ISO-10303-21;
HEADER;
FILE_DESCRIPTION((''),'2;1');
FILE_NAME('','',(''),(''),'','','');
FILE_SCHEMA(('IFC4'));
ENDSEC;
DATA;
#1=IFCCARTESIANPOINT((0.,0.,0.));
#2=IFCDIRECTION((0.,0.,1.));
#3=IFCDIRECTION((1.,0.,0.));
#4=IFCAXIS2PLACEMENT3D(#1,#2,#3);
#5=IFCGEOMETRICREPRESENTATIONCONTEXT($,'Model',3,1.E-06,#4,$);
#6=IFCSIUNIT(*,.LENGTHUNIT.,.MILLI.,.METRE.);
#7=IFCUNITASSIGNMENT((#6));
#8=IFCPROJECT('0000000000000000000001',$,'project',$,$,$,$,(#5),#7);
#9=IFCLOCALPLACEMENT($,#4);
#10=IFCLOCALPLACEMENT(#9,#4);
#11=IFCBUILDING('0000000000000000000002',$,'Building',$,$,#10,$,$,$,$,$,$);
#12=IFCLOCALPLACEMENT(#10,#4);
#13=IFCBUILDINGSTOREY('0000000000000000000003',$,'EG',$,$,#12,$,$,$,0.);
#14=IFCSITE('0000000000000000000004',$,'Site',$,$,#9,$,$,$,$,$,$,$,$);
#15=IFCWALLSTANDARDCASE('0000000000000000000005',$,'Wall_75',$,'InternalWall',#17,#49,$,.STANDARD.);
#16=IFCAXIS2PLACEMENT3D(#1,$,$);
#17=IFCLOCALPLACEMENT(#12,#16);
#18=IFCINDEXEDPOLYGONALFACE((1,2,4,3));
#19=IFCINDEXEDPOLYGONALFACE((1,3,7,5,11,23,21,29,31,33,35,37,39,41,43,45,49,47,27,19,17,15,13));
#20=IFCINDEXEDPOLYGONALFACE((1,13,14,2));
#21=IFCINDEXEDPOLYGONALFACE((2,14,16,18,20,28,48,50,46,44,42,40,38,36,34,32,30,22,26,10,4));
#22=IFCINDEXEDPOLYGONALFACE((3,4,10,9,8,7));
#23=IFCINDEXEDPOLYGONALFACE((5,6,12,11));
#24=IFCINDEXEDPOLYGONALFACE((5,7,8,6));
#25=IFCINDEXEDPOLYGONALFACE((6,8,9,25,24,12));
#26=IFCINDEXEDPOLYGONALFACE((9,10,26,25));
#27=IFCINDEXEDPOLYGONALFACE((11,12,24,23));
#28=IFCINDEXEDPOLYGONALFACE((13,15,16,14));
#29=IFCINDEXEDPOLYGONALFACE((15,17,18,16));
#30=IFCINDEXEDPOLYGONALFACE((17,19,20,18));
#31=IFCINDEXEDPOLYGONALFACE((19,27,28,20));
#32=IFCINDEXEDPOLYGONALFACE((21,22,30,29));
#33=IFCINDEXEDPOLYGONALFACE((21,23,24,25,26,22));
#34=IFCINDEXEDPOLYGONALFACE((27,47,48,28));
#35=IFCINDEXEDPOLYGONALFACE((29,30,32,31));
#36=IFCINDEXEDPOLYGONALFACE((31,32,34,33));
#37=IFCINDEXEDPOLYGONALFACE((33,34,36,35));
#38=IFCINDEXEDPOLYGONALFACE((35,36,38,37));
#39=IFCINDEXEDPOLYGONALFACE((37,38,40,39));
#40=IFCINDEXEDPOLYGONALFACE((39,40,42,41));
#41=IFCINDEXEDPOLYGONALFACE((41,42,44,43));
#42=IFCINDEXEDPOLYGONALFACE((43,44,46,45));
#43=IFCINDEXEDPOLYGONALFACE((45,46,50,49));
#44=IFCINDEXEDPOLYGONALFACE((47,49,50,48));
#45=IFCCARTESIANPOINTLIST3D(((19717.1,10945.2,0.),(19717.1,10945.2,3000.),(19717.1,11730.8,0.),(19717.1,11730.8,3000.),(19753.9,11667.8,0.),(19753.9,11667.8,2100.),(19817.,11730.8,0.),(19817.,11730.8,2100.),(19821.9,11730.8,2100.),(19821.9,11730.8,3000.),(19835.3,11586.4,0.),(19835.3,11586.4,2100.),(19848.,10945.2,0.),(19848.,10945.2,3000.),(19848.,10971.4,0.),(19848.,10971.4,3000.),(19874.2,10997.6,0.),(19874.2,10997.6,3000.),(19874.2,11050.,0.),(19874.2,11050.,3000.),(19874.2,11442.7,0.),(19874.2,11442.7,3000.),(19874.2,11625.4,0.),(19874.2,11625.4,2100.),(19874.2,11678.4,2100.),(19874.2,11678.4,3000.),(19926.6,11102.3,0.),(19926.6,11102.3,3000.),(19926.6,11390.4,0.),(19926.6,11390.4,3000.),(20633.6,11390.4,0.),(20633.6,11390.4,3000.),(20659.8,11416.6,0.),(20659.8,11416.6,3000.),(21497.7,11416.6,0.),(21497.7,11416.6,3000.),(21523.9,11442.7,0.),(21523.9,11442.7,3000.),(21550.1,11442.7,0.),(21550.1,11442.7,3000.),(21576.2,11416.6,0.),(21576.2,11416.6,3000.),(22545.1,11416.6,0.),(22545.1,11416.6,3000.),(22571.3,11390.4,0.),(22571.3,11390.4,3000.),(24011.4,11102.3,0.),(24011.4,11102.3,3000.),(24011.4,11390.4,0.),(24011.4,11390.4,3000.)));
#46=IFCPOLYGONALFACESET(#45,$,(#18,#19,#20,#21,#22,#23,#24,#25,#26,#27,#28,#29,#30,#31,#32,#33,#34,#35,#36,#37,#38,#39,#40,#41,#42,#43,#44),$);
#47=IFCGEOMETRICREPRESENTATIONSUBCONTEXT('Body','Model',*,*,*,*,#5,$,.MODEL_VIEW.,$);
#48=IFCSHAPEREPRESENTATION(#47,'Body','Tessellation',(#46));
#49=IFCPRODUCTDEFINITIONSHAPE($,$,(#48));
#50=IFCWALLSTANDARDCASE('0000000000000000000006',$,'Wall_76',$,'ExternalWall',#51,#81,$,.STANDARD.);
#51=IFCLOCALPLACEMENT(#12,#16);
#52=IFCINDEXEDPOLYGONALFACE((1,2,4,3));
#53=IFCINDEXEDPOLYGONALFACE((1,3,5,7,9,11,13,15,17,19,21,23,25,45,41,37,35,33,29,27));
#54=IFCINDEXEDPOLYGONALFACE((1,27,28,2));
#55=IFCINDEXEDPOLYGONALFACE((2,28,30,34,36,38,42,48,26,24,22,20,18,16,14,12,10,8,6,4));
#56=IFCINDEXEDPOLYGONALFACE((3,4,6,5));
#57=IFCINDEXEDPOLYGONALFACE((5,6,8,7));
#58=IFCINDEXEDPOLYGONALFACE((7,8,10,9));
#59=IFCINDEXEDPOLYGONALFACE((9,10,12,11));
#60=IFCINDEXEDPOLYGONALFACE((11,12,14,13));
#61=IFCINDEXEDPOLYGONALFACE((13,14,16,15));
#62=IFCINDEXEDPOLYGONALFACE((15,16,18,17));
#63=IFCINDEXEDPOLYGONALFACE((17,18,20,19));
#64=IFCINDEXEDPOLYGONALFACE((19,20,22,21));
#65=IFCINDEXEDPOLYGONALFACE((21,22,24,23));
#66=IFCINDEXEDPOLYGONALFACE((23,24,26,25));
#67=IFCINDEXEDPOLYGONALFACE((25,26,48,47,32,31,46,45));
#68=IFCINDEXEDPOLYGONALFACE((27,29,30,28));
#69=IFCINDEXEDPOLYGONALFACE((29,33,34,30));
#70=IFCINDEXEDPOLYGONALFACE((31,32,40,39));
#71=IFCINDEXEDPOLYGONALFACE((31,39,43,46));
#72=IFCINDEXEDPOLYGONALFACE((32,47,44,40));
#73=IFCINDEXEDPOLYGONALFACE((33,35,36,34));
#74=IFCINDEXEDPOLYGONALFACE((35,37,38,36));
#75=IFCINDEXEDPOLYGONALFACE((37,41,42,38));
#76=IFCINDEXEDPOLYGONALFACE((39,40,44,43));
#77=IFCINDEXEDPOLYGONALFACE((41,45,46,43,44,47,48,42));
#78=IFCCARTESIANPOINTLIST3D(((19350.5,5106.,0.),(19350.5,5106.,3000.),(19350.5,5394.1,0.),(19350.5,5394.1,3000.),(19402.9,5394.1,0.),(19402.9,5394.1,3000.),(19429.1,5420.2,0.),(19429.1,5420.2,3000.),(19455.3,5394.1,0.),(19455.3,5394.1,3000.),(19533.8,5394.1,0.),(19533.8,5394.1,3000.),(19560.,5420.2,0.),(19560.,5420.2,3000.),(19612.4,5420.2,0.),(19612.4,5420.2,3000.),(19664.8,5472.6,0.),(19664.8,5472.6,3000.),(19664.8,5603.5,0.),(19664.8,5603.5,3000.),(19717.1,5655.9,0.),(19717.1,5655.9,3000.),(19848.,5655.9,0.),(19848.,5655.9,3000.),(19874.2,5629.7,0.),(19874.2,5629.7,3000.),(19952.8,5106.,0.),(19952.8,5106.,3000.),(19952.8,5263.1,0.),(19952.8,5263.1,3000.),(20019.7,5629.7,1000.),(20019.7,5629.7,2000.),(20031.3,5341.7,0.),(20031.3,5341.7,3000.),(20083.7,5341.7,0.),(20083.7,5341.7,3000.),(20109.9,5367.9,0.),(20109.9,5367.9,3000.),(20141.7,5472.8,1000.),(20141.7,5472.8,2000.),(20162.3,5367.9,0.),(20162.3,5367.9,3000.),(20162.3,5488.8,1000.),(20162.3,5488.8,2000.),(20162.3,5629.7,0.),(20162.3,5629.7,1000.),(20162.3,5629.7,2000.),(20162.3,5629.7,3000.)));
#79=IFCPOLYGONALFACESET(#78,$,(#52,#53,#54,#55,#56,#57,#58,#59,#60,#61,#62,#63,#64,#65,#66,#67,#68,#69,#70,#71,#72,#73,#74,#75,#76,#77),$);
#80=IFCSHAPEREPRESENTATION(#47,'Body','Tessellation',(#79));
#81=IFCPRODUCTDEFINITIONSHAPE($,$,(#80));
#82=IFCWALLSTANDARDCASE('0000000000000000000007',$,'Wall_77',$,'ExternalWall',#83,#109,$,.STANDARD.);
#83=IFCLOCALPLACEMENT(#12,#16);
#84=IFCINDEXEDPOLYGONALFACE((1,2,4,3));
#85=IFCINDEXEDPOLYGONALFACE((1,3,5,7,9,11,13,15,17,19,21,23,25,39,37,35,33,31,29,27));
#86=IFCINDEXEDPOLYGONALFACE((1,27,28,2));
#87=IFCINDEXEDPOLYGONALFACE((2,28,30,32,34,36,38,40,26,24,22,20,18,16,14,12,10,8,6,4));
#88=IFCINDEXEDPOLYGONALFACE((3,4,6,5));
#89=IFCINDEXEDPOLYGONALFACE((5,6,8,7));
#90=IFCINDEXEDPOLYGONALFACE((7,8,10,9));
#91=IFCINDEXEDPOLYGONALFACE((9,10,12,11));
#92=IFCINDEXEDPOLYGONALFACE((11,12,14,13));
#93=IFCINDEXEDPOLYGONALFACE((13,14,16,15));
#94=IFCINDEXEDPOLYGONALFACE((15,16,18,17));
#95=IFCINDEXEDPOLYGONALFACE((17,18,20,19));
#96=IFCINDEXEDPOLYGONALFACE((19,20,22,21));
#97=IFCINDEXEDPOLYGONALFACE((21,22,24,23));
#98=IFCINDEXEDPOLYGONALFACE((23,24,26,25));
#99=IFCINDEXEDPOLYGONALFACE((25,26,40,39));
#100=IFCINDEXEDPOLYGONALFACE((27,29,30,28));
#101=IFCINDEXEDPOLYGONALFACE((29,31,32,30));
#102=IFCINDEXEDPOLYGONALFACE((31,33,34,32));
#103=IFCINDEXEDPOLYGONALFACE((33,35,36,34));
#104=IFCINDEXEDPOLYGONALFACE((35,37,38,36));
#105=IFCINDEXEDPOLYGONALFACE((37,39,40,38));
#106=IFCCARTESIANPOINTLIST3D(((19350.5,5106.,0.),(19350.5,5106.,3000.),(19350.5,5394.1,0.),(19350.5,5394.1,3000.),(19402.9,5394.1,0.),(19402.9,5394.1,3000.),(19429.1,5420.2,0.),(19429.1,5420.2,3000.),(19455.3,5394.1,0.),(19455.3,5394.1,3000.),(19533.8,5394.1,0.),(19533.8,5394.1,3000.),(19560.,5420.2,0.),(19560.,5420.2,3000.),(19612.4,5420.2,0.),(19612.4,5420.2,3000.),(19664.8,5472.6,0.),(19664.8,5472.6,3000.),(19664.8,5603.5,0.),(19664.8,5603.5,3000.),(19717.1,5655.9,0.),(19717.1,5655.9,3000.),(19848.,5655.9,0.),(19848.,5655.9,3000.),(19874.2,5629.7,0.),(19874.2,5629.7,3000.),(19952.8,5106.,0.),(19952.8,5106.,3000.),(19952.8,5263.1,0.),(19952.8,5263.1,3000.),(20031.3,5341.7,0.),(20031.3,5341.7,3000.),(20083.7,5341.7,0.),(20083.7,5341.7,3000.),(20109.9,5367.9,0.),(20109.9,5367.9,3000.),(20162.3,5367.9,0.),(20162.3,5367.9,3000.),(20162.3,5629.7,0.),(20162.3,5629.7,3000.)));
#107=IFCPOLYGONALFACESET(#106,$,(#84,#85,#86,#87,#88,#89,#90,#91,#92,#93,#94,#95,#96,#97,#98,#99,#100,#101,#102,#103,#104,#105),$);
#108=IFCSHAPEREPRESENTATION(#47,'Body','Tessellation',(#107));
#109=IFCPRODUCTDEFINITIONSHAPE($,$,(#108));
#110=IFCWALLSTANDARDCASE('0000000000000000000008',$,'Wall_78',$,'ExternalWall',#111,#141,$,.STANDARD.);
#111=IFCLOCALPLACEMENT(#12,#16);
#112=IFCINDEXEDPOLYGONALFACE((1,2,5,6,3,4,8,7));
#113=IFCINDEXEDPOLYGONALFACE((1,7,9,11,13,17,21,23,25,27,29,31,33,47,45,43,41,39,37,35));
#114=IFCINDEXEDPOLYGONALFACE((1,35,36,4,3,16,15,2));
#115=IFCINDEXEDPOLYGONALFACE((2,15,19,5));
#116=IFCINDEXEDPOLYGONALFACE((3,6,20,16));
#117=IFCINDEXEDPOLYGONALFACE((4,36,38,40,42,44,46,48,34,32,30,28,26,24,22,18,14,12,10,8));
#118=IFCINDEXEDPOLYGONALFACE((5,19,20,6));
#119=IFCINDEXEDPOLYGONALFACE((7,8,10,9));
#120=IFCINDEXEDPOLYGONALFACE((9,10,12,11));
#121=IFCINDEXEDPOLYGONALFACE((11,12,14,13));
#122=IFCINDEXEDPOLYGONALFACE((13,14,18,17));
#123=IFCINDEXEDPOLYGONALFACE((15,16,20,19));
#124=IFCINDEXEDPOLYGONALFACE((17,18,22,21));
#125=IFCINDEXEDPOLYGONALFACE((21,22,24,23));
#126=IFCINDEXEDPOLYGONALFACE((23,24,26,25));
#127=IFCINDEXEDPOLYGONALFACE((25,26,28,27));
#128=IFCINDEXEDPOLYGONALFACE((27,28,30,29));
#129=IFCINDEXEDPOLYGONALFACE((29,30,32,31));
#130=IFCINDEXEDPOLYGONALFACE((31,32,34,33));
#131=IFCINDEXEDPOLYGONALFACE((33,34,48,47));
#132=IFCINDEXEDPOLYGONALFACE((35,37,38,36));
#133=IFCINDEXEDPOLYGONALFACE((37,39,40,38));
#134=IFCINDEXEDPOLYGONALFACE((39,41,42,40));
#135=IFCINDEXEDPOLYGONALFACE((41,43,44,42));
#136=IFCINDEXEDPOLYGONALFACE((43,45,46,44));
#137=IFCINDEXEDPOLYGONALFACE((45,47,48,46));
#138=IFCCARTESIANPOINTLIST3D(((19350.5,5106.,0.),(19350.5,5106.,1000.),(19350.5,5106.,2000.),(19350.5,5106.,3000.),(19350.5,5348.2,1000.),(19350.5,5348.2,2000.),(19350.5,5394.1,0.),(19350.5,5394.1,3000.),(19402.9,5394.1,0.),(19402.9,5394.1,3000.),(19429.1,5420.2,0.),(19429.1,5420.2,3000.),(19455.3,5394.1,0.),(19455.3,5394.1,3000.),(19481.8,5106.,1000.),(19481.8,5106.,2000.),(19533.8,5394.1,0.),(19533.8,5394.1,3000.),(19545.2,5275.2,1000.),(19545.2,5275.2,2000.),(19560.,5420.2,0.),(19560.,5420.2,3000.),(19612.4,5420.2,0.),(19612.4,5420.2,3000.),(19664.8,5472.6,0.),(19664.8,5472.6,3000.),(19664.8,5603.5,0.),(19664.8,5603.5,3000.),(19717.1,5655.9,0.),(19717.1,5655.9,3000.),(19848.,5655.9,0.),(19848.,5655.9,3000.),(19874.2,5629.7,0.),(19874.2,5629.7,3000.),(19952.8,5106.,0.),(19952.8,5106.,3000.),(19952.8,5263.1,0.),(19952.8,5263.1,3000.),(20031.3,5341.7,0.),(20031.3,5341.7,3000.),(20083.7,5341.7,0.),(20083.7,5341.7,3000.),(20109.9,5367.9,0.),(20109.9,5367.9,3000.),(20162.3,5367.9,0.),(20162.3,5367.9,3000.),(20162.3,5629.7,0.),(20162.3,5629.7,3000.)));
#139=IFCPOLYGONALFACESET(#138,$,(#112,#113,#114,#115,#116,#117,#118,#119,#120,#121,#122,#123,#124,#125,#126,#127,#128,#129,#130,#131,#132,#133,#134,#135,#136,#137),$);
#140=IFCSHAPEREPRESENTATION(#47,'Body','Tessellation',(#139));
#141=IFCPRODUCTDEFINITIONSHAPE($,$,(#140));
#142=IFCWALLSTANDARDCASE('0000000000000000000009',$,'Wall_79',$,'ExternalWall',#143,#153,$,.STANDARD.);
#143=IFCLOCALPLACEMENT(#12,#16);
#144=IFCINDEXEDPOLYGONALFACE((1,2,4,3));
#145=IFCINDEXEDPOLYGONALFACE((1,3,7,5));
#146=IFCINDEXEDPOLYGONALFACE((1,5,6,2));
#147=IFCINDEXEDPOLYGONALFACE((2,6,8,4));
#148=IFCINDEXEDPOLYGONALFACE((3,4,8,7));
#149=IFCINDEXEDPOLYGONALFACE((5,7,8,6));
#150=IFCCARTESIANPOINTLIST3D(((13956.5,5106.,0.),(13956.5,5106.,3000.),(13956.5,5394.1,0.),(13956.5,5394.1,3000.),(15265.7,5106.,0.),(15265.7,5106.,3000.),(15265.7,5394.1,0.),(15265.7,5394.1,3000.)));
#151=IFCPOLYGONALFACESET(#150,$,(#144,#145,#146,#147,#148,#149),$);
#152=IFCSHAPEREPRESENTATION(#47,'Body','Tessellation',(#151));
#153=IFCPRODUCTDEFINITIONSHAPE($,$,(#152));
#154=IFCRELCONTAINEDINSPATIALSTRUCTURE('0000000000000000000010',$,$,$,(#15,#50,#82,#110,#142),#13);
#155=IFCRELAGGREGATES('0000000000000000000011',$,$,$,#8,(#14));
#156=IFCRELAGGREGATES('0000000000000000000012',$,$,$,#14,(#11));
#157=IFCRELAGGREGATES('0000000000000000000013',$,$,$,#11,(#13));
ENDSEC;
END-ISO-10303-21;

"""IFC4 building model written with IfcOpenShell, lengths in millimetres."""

from ifc_helpers import new_model, si_unit, frame, origin_with_axes, place, context, subcontext, project, spatial, polyline, rectangle, outline, extrude, element, save


model = new_model("IFC4")

# Units and contexts
model_context = context("Model", 3, precision=1e-06, world=origin_with_axes())
body_context = subcontext(model_context, "Body", "Model", "MODEL_VIEW")
ifc_project = project(units=[si_unit("LENGTHUNIT", "METRE", prefix="MILLI")], contexts=[model_context])

# Site, building, storey
site_placement = place(None, origin_with_axes())
site = spatial("IfcSite", under=ifc_project, at=site_placement, Name="Site")
building_placement = place(site_placement, origin_with_axes())
building = spatial("IfcBuilding", under=site, at=building_placement, Name="Building")
storey_placement = place(building_placement, origin_with_axes())
storey = spatial("IfcBuildingStorey", under=building, at=storey_placement, Name="EG", Elevation=0.0)

# Walls, openings
wall_1_placement = place(storey_placement, origin_with_axes())
wall_1 = element("IfcWallStandardCase", 1, at=wall_1_placement, inside=storey, Name="Wall_75", ObjectType="InternalWall", PredefinedType="STANDARD", context=body_context, shape_type="SweptSolid", body=[
    extrude(outline(polyline([(19717.1, 10945.2, 0.0), (19717.1, 11730.8, 0.0), (19821.9, 11730.8, 0.0), (19874.2, 11678.4, 0.0), (19874.2, 11442.7, 0.0), (19926.6, 11390.4, 0.0), (20633.6, 11390.4, 0.0), (20659.8, 11416.6, 0.0), (21497.7, 11416.6, 0.0), (21523.9, 11442.7, 0.0), (21550.1, 11442.7, 0.0), (21576.2, 11416.6, 0.0), (22545.1, 11416.6, 0.0), (22571.3, 11390.4, 0.0), (24011.4, 11390.4, 0.0), (24011.4, 11102.3, 0.0), (19926.6, 11102.3, 0.0), (19874.2, 11050.0, 0.0), (19874.2, 10997.6, 0.0), (19848.0, 10971.4, 0.0), (19848.0, 10945.2, 0.0), (19717.1, 10945.2, 0.0)])), origin_with_axes(), (0.0, 0.0, 1.0), 3000.0),
])
opening_1_placement = place(wall_1_placement, origin_with_axes())
element("IfcOpeningElement", 2, at=opening_1_placement, inside=storey, cuts=wall_1, context=body_context, shape_type="SweptSolid", body=[
    extrude(rectangle(XDim=907.3, YDim=115.0), frame((20115.4, 11947.9, 0.0), z_axis=(0.0, 0.0, 1.0), x_axis=(0.707107, 0.707107, 0.0)), (0.0, 0.0, 1.0), 2100.0),
])
wall_2_placement = place(storey_placement, origin_with_axes())
wall_2 = element("IfcWallStandardCase", 3, at=wall_2_placement, inside=storey, Name="Wall_76", ObjectType="ExternalWall", PredefinedType="STANDARD", context=body_context, shape_type="SweptSolid", body=[
    extrude(outline(polyline([(19350.5, 5106.0, 0.0), (19350.5, 5394.1, 0.0), (19402.9, 5394.1, 0.0), (19429.1, 5420.2, 0.0), (19455.3, 5394.1, 0.0), (19533.8, 5394.1, 0.0), (19560.0, 5420.2, 0.0), (19612.4, 5420.2, 0.0), (19664.8, 5472.6, 0.0), (19664.8, 5603.5, 0.0), (19717.1, 5655.9, 0.0), (19848.0, 5655.9, 0.0), (19874.2, 5629.7, 0.0), (20162.3, 5629.7, 0.0), (20162.3, 5367.9, 0.0), (20109.9, 5367.9, 0.0), (20083.7, 5341.7, 0.0), (20031.3, 5341.7, 0.0), (19952.8, 5263.1, 0.0), (19952.8, 5106.0, 0.0), (19350.5, 5106.0, 0.0)])), origin_with_axes(), (0.0, 0.0, 1.0), 3000.0),
])
opening_2_placement = place(wall_2_placement, origin_with_axes())
element("IfcOpeningElement", 4, at=opening_2_placement, inside=storey, cuts=wall_2, context=body_context, shape_type="SweptSolid", body=[
    extrude(rectangle(XDim=2923.5, YDim=240.0), frame((21221.9, 6465.0, 1000.0), z_axis=(0.0, 0.0, 1.0), x_axis=(-0.789352, -0.613941, 0.0)), (0.0, 0.0, 1.0), 1000.0),
])

# Wall
wall_3_placement = place(storey_placement, origin_with_axes())
element("IfcWallStandardCase", 5, at=wall_3_placement, inside=storey, Name="Wall_77", ObjectType="ExternalWall", PredefinedType="STANDARD", context=body_context, shape_type="SweptSolid", body=[
    extrude(outline(polyline([(19350.5, 5106.0, 0.0), (19350.5, 5394.1, 0.0), (19402.9, 5394.1, 0.0), (19429.1, 5420.2, 0.0), (19455.3, 5394.1, 0.0), (19533.8, 5394.1, 0.0), (19560.0, 5420.2, 0.0), (19612.4, 5420.2, 0.0), (19664.8, 5472.6, 0.0), (19664.8, 5603.5, 0.0), (19717.1, 5655.9, 0.0), (19848.0, 5655.9, 0.0), (19874.2, 5629.7, 0.0), (20162.3, 5629.7, 0.0), (20162.3, 5367.9, 0.0), (20109.9, 5367.9, 0.0), (20083.7, 5341.7, 0.0), (20031.3, 5341.7, 0.0), (19952.8, 5263.1, 0.0), (19952.8, 5106.0, 0.0), (19350.5, 5106.0, 0.0)])), origin_with_axes(), (0.0, 0.0, 1.0), 3000.0),
])

# Wall, opening
wall_4_placement = place(storey_placement, origin_with_axes())
wall_4 = element("IfcWallStandardCase", 6, at=wall_4_placement, inside=storey, Name="Wall_78", ObjectType="ExternalWall", PredefinedType="STANDARD", context=body_context, shape_type="SweptSolid", body=[
    extrude(outline(polyline([(19350.5, 5106.0, 0.0), (19350.5, 5394.1, 0.0), (19402.9, 5394.1, 0.0), (19429.1, 5420.2, 0.0), (19455.3, 5394.1, 0.0), (19533.8, 5394.1, 0.0), (19560.0, 5420.2, 0.0), (19612.4, 5420.2, 0.0), (19664.8, 5472.6, 0.0), (19664.8, 5603.5, 0.0), (19717.1, 5655.9, 0.0), (19848.0, 5655.9, 0.0), (19874.2, 5629.7, 0.0), (20162.3, 5629.7, 0.0), (20162.3, 5367.9, 0.0), (20109.9, 5367.9, 0.0), (20083.7, 5341.7, 0.0), (20031.3, 5341.7, 0.0), (19952.8, 5263.1, 0.0), (19952.8, 5106.0, 0.0), (19350.5, 5106.0, 0.0)])), origin_with_axes(), (0.0, 0.0, 1.0), 3000.0),
])
opening_3_placement = place(wall_4_placement, origin_with_axes())
element("IfcOpeningElement", 7, at=opening_3_placement, inside=storey, cuts=wall_4, context=body_context, shape_type="SweptSolid", body=[
    extrude(rectangle(XDim=686.5, YDim=240.0), frame((19312.4, 4996.0, 1000.0), z_axis=(0.0, 0.0, 1.0), x_axis=(0.351123, 0.936329, 0.0)), (0.0, 0.0, 1.0), 1000.0),
])

# Wall
for number, where, z_axis, x_axis, name in (
    (8, (0.0, 0.0, 0.0), (0.0, 0.0, 1.0), (1.0, 0.0, 0.0), "Wall_79"),
):
    element("IfcWallStandardCase", number, at=place(storey_placement, frame(where, z_axis=z_axis, x_axis=x_axis)), inside=storey, Name=name, ObjectType="ExternalWall", PredefinedType="STANDARD", context=body_context, shape_type="SweptSolid", body=[
        extrude(outline(polyline([(13956.5, 5106.0, 0.0), (13956.5, 5394.1, 0.0), (15265.7, 5394.1, 0.0), (15265.7, 5106.0, 0.0), (13956.5, 5106.0, 0.0)])), origin_with_axes(), (0.0, 0.0, 1.0), 3000.0),
    ])

save(model, "model.ifc")
